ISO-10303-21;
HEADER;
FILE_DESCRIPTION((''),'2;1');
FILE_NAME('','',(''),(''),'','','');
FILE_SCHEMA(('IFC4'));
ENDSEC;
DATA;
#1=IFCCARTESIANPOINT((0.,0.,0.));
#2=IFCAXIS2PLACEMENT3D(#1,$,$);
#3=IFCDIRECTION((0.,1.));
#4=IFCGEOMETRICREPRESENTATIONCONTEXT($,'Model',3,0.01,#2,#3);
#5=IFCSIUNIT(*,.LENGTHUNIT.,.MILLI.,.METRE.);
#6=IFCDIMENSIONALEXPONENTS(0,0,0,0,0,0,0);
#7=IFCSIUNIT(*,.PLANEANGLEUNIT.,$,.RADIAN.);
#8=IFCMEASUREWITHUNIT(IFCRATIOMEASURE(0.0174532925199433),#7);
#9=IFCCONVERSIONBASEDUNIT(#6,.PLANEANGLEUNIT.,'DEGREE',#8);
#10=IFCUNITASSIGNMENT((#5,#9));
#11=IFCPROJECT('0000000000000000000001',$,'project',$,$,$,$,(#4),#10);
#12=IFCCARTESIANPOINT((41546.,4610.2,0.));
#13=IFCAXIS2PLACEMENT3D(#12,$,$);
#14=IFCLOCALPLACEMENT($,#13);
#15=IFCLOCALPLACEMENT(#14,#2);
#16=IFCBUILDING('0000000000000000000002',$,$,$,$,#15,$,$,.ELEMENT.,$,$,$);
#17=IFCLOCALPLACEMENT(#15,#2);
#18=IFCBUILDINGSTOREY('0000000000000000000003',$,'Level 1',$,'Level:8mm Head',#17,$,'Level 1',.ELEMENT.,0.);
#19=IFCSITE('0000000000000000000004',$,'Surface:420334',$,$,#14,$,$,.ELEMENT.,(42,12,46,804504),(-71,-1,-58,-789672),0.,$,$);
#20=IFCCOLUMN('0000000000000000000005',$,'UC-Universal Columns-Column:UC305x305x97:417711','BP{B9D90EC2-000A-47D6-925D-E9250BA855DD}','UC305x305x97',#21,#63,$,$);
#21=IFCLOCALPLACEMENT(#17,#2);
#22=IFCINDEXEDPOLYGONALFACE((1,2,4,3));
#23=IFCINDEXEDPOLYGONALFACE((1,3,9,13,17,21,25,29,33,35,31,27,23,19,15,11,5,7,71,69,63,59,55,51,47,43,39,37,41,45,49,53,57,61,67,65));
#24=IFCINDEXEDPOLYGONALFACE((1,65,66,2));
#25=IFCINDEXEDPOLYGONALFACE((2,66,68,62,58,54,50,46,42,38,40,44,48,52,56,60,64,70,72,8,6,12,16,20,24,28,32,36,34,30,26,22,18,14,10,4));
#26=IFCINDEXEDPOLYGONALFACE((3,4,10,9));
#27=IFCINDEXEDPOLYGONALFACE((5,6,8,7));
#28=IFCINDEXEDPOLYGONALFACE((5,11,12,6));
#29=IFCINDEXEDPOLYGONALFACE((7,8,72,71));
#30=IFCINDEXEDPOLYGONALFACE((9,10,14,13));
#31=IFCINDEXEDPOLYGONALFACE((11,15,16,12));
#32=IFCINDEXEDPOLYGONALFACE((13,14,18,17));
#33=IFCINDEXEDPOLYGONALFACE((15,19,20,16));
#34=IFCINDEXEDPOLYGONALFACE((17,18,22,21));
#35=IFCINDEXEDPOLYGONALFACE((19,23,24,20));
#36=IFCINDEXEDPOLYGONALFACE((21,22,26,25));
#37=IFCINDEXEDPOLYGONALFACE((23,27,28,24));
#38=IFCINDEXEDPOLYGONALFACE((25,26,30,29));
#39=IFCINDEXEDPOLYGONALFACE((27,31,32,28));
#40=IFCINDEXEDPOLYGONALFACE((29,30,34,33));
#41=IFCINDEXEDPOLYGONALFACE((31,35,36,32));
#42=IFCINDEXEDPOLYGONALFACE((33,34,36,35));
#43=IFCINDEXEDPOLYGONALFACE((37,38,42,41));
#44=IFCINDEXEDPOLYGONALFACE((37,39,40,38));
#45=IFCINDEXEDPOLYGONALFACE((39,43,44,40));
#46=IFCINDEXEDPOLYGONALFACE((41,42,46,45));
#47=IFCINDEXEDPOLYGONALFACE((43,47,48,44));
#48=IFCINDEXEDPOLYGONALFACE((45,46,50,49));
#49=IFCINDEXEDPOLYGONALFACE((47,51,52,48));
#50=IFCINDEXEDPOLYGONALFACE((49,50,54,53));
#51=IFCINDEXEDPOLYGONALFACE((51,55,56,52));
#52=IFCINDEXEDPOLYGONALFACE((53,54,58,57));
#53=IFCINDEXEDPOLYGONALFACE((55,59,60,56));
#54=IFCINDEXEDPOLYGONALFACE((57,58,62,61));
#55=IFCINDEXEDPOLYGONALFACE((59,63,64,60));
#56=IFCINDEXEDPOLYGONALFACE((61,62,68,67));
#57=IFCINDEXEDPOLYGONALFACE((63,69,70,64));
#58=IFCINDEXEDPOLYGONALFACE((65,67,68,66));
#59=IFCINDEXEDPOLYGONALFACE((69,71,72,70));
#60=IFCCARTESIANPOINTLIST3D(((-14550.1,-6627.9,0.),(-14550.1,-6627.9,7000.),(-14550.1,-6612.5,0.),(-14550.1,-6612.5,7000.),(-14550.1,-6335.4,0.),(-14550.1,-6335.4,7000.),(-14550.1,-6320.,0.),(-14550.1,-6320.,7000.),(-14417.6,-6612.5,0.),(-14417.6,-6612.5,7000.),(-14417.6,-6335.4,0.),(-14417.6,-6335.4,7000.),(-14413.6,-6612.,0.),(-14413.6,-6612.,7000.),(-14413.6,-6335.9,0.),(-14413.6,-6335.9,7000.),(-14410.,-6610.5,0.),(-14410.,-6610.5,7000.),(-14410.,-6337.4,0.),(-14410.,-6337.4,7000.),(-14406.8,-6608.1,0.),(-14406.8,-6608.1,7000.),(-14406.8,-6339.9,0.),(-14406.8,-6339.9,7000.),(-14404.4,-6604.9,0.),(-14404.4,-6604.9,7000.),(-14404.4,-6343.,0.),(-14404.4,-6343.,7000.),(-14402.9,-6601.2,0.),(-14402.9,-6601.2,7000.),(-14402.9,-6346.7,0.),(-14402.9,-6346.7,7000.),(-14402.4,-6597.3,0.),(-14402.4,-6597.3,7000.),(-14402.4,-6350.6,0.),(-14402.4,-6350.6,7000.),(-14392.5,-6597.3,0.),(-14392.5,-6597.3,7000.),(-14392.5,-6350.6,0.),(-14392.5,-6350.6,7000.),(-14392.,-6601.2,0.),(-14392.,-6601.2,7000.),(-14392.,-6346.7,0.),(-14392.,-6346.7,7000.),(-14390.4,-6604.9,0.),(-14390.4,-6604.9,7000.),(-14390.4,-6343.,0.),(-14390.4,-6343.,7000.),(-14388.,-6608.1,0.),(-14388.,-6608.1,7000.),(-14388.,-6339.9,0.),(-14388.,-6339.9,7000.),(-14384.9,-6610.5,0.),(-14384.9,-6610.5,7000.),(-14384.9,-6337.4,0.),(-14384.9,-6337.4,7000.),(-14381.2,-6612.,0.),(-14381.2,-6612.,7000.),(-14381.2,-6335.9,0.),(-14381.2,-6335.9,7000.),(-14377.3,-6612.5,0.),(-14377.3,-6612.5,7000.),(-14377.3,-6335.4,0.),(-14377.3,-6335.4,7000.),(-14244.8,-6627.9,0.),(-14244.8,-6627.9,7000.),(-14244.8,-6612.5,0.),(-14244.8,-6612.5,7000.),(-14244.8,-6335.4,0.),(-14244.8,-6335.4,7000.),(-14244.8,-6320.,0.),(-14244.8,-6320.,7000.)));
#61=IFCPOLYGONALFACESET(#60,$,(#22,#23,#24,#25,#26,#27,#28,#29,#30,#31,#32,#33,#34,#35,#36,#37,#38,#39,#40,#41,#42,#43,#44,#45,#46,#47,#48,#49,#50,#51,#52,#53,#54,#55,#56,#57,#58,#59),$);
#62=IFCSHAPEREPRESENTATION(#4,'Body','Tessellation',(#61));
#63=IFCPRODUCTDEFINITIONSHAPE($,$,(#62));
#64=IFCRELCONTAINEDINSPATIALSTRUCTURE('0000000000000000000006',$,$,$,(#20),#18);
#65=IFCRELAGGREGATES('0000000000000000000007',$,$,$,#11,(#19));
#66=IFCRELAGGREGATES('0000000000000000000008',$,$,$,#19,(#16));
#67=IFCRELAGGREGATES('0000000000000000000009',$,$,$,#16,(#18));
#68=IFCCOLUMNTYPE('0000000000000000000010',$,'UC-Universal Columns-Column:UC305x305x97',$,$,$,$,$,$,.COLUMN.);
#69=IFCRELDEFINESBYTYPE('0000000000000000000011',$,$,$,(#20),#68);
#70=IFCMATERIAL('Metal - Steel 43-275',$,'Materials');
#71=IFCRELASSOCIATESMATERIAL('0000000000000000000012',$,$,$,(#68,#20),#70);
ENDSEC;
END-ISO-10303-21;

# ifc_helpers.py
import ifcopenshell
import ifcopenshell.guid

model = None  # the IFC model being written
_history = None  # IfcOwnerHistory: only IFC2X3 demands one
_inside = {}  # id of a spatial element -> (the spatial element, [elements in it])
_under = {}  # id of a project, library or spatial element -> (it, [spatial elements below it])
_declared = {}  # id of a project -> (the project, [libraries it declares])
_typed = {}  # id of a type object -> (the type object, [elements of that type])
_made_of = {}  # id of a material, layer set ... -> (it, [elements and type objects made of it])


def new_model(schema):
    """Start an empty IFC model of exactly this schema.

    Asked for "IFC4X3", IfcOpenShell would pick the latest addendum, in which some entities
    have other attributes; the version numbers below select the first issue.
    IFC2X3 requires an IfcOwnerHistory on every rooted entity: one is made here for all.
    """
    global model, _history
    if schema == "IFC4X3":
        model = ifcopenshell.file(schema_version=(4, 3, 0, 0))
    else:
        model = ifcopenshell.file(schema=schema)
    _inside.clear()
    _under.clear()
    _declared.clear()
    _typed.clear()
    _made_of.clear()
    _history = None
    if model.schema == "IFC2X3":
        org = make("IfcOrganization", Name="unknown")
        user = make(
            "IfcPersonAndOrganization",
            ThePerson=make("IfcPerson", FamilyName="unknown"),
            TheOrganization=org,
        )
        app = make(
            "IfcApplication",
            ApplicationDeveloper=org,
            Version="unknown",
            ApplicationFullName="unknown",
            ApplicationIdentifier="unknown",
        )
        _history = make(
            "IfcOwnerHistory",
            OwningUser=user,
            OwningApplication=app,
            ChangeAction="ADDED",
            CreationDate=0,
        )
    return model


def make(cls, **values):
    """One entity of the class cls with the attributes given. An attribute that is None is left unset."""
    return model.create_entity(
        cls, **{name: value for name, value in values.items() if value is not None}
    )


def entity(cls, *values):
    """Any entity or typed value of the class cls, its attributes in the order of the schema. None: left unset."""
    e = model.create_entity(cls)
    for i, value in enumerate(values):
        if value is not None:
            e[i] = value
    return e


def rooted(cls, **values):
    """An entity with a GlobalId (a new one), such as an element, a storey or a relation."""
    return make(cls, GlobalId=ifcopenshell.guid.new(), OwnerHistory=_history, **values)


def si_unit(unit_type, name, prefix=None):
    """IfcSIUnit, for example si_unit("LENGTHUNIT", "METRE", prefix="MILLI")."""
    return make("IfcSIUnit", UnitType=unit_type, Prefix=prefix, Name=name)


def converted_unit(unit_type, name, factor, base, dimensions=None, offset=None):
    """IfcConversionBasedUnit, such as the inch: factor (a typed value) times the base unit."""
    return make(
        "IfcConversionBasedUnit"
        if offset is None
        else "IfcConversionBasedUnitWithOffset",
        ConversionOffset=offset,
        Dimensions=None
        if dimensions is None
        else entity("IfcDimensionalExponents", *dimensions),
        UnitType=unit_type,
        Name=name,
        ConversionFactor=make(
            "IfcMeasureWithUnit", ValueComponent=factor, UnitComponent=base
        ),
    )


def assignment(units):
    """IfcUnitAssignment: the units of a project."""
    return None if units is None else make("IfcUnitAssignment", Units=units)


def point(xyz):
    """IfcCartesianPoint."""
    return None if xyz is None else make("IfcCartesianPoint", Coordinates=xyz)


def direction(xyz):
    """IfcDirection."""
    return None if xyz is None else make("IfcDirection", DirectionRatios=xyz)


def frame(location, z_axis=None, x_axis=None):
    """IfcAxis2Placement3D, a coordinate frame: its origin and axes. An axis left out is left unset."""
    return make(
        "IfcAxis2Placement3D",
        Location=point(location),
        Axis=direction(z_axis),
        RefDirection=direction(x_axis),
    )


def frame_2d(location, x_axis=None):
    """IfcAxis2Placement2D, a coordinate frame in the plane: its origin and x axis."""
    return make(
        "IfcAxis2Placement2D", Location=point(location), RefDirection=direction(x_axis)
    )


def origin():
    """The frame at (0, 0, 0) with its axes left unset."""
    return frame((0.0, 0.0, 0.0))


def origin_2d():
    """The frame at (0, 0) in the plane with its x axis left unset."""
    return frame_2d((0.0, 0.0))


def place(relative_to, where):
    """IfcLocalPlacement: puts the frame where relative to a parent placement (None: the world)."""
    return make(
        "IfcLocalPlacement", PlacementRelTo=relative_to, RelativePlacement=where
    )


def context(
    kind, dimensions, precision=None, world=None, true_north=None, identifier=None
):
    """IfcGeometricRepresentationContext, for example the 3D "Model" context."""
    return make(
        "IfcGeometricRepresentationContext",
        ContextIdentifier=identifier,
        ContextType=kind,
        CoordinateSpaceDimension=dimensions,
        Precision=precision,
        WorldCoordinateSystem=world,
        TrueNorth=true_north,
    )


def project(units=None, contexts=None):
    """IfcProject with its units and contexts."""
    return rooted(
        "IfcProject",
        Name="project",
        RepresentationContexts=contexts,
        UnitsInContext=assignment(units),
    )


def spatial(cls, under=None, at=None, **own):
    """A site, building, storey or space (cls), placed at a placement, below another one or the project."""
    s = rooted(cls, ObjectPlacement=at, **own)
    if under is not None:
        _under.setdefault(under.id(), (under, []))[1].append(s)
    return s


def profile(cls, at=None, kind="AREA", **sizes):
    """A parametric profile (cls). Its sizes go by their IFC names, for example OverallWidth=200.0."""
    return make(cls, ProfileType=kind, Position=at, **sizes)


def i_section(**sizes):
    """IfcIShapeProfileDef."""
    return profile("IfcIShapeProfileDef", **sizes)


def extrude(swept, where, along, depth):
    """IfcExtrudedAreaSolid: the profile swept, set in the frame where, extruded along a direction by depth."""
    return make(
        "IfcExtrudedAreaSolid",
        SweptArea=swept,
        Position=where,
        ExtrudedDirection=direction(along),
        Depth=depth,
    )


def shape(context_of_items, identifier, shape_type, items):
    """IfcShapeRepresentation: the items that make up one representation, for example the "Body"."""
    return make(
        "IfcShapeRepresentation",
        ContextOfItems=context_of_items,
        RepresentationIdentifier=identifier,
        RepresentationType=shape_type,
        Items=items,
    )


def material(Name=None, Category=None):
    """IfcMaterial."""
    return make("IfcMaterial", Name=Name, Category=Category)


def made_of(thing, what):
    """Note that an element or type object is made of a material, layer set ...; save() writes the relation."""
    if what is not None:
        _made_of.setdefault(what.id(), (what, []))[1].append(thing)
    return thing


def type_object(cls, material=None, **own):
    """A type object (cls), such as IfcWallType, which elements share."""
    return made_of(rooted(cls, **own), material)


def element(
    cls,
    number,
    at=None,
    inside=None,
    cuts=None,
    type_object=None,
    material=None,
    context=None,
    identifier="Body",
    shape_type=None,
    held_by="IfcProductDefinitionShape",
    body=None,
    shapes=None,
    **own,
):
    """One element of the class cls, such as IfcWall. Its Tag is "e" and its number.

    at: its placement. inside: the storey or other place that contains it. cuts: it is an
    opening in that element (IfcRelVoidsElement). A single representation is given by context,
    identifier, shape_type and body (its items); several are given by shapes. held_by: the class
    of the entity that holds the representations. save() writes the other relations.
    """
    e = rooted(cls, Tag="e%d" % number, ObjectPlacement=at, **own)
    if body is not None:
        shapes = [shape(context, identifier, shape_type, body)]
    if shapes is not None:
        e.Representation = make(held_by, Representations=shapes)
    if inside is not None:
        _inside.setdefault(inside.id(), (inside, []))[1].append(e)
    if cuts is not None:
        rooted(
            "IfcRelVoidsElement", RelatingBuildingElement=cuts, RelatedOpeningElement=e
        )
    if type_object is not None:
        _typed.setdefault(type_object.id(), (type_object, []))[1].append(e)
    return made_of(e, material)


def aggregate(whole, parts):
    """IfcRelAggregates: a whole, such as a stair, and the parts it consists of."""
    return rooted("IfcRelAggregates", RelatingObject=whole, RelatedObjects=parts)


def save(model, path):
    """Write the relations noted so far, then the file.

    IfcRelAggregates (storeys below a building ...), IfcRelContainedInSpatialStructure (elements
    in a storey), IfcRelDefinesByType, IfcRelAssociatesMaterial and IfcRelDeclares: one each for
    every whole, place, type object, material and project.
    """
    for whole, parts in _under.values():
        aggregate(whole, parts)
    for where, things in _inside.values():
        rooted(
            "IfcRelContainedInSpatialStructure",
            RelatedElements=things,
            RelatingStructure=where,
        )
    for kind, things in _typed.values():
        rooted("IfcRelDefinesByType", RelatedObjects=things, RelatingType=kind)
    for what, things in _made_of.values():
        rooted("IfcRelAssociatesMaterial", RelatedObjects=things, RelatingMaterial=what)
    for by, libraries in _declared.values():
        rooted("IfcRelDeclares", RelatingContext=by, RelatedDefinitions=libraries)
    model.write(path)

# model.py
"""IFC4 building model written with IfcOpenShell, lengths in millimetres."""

from ifc_helpers import new_model, entity, si_unit, converted_unit, direction, frame, origin, origin_2d, place, context, project, spatial, i_section, extrude, material, type_object, element, save


model = new_model("IFC4")

# Units and contexts
model_context = context("Model", 3, precision=0.01, world=origin(), true_north=direction((0.0, 1.0)))
ifc_project = project(units=[si_unit("LENGTHUNIT", "METRE", prefix="MILLI"), converted_unit("PLANEANGLEUNIT", "DEGREE", entity("IfcRatioMeasure", 0.0174532925199433), si_unit("PLANEANGLEUNIT", "RADIAN"), dimensions=[0, 0, 0, 0, 0, 0, 0])], contexts=[model_context])

# Site, building, storey
site_placement = place(None, frame((41546.0, 4610.2, 0.0)))
site = spatial("IfcSite", under=ifc_project, at=site_placement, Name="Surface:420334", CompositionType="ELEMENT", RefLatitude=(42, 12, 46, 804504), RefLongitude=(-71, -1, -58, -789672), RefElevation=0.0)
building_placement = place(site_placement, origin())
building = spatial("IfcBuilding", under=site, at=building_placement, CompositionType="ELEMENT")
storey_placement = place(building_placement, origin())
storey = spatial("IfcBuildingStorey", under=building, at=storey_placement, Name="Level 1", ObjectType="Level:8mm Head", LongName="Level 1", CompositionType="ELEMENT", Elevation=0.0)

# Column
ifc_material = material(Name="Metal - Steel 43-275", Category="Materials")
column_type = type_object("IfcColumnType", Name="UC-Universal Columns-Column:UC305x305x97", PredefinedType="COLUMN", material=ifc_material)
column_placement = place(storey_placement, frame((-14397.4, -6474.0, 7000.0)))
element("IfcColumn", 1, at=column_placement, inside=storey, type_object=column_type, material=ifc_material, Name="UC-Universal Columns-Column:UC305x305x97:417711", Description="BP{B9D90EC2-000A-47D6-925D-E9250BA855DD}", ObjectType="UC305x305x97", context=model_context, shape_type="SweptSolid", body=[
    extrude(i_section(OverallWidth=305.3, OverallDepth=307.9, WebThickness=9.9, FlangeThickness=15.4, FilletRadius=15.2, at=origin_2d()), origin(), (0.0, 0.0, -1.0), 7000.0),
])

save(model, "model.ifc")
